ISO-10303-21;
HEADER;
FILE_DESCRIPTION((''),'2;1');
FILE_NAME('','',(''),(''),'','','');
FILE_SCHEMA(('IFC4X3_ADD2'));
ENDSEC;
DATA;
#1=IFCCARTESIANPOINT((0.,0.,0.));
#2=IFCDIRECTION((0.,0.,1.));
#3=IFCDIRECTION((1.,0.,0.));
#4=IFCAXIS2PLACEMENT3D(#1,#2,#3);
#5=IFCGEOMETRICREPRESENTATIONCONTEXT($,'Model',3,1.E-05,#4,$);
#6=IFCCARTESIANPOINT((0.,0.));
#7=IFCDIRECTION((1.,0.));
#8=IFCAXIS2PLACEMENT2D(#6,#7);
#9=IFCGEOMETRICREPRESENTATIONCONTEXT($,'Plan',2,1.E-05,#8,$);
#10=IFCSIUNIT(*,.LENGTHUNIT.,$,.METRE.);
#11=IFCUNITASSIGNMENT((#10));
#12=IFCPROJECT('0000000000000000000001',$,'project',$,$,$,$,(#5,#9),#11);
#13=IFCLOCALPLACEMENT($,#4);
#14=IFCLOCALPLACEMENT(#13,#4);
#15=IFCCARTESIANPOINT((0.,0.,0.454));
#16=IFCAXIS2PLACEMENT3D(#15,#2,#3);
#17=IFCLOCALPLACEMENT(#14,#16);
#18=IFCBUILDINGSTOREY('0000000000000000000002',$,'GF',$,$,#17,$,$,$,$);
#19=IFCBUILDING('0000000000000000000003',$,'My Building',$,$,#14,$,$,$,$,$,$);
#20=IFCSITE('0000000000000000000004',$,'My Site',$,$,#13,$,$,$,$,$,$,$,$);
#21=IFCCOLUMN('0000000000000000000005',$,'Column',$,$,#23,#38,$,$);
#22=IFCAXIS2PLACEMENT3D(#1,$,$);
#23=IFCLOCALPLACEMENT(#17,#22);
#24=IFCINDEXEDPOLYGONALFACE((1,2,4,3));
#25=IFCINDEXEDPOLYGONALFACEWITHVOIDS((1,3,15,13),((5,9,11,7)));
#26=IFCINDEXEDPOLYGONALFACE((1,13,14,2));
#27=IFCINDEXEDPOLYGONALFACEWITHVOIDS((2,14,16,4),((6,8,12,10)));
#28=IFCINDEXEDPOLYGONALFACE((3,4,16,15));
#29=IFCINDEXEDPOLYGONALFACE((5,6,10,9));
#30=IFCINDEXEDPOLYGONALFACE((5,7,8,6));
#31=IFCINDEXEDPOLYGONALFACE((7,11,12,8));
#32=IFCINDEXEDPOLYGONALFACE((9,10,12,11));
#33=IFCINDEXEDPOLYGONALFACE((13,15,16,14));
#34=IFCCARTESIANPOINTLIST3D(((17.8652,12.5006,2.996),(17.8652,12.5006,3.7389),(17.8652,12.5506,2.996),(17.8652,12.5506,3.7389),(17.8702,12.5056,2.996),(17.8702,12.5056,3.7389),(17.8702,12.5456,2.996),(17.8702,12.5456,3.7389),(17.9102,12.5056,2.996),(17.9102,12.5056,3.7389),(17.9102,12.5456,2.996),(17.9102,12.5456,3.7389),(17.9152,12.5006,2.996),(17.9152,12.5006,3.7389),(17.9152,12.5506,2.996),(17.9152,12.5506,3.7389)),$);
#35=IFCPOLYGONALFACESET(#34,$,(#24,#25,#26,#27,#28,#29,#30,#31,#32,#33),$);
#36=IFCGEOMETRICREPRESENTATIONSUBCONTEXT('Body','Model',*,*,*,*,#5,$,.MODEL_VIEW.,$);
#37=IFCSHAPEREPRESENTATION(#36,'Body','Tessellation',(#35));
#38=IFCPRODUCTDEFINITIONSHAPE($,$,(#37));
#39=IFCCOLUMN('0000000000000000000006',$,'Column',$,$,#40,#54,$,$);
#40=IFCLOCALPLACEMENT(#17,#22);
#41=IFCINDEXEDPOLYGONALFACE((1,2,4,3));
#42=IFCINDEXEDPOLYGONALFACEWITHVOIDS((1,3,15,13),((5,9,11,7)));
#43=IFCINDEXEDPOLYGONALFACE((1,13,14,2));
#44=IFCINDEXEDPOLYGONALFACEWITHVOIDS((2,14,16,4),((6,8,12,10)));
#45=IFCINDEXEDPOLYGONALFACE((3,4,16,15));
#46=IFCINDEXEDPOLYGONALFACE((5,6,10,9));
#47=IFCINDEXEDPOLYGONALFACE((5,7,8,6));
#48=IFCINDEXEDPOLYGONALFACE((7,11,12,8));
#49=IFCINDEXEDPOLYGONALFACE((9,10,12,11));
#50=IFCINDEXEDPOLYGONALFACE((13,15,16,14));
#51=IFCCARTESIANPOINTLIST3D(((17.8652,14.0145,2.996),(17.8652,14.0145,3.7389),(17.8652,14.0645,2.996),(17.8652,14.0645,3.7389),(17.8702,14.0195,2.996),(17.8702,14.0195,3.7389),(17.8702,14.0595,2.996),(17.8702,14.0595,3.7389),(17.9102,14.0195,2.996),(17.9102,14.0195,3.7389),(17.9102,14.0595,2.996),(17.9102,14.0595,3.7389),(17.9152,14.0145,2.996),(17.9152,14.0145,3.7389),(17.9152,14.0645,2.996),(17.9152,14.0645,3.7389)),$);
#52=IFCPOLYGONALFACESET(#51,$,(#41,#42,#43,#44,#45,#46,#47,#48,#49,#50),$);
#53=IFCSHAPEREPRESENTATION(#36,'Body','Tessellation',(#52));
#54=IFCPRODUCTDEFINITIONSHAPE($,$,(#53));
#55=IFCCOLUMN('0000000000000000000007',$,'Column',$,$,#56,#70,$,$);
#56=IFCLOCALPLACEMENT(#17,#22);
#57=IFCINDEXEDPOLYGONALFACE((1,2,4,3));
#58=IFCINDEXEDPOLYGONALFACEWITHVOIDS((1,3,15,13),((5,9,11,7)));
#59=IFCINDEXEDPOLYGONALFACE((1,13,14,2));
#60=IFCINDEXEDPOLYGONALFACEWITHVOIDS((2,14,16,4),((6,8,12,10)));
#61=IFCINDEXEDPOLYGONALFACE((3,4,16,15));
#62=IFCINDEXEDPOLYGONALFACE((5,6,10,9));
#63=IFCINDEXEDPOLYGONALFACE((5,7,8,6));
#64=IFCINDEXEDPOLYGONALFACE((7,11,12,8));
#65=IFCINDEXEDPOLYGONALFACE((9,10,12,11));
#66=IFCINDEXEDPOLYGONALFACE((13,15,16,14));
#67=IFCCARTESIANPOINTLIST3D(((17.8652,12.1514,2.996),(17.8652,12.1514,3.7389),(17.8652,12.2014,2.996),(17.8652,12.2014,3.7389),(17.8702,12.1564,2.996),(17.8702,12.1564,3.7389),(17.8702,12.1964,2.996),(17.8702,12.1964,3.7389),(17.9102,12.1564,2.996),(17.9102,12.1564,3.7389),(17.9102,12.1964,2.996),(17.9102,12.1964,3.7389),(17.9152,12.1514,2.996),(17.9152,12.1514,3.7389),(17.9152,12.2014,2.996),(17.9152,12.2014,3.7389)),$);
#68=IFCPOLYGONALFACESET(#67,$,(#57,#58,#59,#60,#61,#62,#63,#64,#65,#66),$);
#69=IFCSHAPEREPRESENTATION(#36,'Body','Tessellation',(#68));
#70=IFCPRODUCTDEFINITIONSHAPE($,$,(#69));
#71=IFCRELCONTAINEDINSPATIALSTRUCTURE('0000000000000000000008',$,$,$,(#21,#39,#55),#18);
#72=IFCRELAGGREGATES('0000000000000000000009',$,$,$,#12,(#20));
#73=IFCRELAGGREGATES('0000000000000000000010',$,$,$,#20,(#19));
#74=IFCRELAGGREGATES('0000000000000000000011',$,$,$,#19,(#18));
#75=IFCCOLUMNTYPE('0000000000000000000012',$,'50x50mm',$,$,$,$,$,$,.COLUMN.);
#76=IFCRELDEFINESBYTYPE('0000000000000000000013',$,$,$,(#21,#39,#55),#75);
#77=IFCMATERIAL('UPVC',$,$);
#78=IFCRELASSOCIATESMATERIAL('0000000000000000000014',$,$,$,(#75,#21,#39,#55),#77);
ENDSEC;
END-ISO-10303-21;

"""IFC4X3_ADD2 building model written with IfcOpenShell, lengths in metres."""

from ifc_helpers import new_model, si_unit, frame, origin_with_axes, origin_2d_with_axis, place, context, subcontext, project, spatial, hollow_rectangle, extrude, material, material_profile, profile_set, profile_usage, type_object, element, save


model = new_model("IFC4X3_ADD2")

# Units and contexts
model_context = context("Model", 3, precision=1e-05, world=origin_with_axes())
plan_context = context("Plan", 2, precision=1e-05, world=origin_2d_with_axis())
body_context = subcontext(model_context, "Body", "Model", "MODEL_VIEW")
ifc_project = project(units=[si_unit("LENGTHUNIT", "METRE")], contexts=[model_context, plan_context])

# Site, building, storey
site_placement = place(None, origin_with_axes())
site = spatial("IfcSite", under=ifc_project, at=site_placement, Name="My Site")
building_placement = place(site_placement, origin_with_axes())
building = spatial("IfcBuilding", under=site, at=building_placement, Name="My Building")
storey_placement = place(building_placement, frame((0.0, 0.0, 0.454), z_axis=(0.0, 0.0, 1.0), x_axis=(1.0, 0.0, 0.0)))
storey = spatial("IfcBuildingStorey", under=building, at=storey_placement, Name="GF")

# Columns
ifc_material = material(Name="UPVC")
ifc_material_profile_1 = material_profile(ifc_material, hollow_rectangle(XDim=0.05, YDim=0.05, WallThickness=0.005))
ifc_profile_set_1 = profile_set([ifc_material_profile_1])
column_type_1 = type_object("IfcColumnType", Name="50x50mm", PredefinedType="COLUMN", material=ifc_profile_set_1)
ifc_profile_usage_1 = profile_usage(ifc_profile_set_1)
column_1_placement = place(storey_placement, frame((17.8902, 12.5256, 2.996), z_axis=(0.0, 0.0, 1.0), x_axis=(0.0, -1.0, 0.0)))
element("IfcColumn", 1, at=column_1_placement, inside=storey, type_object=column_type_1, material=ifc_profile_usage_1, Name="Column", context=body_context, shape_type="SweptSolid", body=[
    extrude(hollow_rectangle(XDim=0.05, YDim=0.05, WallThickness=0.005), origin_with_axes(), (0.0, 0.0, 1.0), 0.7429),
])
ifc_profile_usage_2 = profile_usage(ifc_profile_set_1)
column_2_placement = place(storey_placement, frame((17.8902, 14.0395, 2.996), z_axis=(0.0, 0.0, 1.0), x_axis=(0.0, -1.0, 0.0)))
element("IfcColumn", 2, at=column_2_placement, inside=storey, type_object=column_type_1, material=ifc_profile_usage_2, Name="Column", context=body_context, shape_type="SweptSolid", body=[
    extrude(hollow_rectangle(XDim=0.05, YDim=0.05, WallThickness=0.005), origin_with_axes(), (0.0, 0.0, 1.0), 0.7429),
])
ifc_profile_usage_3 = profile_usage(ifc_profile_set_1)
column_3_placement = place(storey_placement, frame((17.8902, 12.1764, 2.996), z_axis=(0.0, 0.0, 1.0), x_axis=(0.0, -1.0, 0.0)))
element("IfcColumn", 3, at=column_3_placement, inside=storey, type_object=column_type_1, material=ifc_profile_usage_3, Name="Column", context=body_context, shape_type="SweptSolid", body=[
    extrude(hollow_rectangle(XDim=0.05, YDim=0.05, WallThickness=0.005), origin_with_axes(), (0.0, 0.0, 1.0), 0.7429),
])

save(model, "model.ifc")
